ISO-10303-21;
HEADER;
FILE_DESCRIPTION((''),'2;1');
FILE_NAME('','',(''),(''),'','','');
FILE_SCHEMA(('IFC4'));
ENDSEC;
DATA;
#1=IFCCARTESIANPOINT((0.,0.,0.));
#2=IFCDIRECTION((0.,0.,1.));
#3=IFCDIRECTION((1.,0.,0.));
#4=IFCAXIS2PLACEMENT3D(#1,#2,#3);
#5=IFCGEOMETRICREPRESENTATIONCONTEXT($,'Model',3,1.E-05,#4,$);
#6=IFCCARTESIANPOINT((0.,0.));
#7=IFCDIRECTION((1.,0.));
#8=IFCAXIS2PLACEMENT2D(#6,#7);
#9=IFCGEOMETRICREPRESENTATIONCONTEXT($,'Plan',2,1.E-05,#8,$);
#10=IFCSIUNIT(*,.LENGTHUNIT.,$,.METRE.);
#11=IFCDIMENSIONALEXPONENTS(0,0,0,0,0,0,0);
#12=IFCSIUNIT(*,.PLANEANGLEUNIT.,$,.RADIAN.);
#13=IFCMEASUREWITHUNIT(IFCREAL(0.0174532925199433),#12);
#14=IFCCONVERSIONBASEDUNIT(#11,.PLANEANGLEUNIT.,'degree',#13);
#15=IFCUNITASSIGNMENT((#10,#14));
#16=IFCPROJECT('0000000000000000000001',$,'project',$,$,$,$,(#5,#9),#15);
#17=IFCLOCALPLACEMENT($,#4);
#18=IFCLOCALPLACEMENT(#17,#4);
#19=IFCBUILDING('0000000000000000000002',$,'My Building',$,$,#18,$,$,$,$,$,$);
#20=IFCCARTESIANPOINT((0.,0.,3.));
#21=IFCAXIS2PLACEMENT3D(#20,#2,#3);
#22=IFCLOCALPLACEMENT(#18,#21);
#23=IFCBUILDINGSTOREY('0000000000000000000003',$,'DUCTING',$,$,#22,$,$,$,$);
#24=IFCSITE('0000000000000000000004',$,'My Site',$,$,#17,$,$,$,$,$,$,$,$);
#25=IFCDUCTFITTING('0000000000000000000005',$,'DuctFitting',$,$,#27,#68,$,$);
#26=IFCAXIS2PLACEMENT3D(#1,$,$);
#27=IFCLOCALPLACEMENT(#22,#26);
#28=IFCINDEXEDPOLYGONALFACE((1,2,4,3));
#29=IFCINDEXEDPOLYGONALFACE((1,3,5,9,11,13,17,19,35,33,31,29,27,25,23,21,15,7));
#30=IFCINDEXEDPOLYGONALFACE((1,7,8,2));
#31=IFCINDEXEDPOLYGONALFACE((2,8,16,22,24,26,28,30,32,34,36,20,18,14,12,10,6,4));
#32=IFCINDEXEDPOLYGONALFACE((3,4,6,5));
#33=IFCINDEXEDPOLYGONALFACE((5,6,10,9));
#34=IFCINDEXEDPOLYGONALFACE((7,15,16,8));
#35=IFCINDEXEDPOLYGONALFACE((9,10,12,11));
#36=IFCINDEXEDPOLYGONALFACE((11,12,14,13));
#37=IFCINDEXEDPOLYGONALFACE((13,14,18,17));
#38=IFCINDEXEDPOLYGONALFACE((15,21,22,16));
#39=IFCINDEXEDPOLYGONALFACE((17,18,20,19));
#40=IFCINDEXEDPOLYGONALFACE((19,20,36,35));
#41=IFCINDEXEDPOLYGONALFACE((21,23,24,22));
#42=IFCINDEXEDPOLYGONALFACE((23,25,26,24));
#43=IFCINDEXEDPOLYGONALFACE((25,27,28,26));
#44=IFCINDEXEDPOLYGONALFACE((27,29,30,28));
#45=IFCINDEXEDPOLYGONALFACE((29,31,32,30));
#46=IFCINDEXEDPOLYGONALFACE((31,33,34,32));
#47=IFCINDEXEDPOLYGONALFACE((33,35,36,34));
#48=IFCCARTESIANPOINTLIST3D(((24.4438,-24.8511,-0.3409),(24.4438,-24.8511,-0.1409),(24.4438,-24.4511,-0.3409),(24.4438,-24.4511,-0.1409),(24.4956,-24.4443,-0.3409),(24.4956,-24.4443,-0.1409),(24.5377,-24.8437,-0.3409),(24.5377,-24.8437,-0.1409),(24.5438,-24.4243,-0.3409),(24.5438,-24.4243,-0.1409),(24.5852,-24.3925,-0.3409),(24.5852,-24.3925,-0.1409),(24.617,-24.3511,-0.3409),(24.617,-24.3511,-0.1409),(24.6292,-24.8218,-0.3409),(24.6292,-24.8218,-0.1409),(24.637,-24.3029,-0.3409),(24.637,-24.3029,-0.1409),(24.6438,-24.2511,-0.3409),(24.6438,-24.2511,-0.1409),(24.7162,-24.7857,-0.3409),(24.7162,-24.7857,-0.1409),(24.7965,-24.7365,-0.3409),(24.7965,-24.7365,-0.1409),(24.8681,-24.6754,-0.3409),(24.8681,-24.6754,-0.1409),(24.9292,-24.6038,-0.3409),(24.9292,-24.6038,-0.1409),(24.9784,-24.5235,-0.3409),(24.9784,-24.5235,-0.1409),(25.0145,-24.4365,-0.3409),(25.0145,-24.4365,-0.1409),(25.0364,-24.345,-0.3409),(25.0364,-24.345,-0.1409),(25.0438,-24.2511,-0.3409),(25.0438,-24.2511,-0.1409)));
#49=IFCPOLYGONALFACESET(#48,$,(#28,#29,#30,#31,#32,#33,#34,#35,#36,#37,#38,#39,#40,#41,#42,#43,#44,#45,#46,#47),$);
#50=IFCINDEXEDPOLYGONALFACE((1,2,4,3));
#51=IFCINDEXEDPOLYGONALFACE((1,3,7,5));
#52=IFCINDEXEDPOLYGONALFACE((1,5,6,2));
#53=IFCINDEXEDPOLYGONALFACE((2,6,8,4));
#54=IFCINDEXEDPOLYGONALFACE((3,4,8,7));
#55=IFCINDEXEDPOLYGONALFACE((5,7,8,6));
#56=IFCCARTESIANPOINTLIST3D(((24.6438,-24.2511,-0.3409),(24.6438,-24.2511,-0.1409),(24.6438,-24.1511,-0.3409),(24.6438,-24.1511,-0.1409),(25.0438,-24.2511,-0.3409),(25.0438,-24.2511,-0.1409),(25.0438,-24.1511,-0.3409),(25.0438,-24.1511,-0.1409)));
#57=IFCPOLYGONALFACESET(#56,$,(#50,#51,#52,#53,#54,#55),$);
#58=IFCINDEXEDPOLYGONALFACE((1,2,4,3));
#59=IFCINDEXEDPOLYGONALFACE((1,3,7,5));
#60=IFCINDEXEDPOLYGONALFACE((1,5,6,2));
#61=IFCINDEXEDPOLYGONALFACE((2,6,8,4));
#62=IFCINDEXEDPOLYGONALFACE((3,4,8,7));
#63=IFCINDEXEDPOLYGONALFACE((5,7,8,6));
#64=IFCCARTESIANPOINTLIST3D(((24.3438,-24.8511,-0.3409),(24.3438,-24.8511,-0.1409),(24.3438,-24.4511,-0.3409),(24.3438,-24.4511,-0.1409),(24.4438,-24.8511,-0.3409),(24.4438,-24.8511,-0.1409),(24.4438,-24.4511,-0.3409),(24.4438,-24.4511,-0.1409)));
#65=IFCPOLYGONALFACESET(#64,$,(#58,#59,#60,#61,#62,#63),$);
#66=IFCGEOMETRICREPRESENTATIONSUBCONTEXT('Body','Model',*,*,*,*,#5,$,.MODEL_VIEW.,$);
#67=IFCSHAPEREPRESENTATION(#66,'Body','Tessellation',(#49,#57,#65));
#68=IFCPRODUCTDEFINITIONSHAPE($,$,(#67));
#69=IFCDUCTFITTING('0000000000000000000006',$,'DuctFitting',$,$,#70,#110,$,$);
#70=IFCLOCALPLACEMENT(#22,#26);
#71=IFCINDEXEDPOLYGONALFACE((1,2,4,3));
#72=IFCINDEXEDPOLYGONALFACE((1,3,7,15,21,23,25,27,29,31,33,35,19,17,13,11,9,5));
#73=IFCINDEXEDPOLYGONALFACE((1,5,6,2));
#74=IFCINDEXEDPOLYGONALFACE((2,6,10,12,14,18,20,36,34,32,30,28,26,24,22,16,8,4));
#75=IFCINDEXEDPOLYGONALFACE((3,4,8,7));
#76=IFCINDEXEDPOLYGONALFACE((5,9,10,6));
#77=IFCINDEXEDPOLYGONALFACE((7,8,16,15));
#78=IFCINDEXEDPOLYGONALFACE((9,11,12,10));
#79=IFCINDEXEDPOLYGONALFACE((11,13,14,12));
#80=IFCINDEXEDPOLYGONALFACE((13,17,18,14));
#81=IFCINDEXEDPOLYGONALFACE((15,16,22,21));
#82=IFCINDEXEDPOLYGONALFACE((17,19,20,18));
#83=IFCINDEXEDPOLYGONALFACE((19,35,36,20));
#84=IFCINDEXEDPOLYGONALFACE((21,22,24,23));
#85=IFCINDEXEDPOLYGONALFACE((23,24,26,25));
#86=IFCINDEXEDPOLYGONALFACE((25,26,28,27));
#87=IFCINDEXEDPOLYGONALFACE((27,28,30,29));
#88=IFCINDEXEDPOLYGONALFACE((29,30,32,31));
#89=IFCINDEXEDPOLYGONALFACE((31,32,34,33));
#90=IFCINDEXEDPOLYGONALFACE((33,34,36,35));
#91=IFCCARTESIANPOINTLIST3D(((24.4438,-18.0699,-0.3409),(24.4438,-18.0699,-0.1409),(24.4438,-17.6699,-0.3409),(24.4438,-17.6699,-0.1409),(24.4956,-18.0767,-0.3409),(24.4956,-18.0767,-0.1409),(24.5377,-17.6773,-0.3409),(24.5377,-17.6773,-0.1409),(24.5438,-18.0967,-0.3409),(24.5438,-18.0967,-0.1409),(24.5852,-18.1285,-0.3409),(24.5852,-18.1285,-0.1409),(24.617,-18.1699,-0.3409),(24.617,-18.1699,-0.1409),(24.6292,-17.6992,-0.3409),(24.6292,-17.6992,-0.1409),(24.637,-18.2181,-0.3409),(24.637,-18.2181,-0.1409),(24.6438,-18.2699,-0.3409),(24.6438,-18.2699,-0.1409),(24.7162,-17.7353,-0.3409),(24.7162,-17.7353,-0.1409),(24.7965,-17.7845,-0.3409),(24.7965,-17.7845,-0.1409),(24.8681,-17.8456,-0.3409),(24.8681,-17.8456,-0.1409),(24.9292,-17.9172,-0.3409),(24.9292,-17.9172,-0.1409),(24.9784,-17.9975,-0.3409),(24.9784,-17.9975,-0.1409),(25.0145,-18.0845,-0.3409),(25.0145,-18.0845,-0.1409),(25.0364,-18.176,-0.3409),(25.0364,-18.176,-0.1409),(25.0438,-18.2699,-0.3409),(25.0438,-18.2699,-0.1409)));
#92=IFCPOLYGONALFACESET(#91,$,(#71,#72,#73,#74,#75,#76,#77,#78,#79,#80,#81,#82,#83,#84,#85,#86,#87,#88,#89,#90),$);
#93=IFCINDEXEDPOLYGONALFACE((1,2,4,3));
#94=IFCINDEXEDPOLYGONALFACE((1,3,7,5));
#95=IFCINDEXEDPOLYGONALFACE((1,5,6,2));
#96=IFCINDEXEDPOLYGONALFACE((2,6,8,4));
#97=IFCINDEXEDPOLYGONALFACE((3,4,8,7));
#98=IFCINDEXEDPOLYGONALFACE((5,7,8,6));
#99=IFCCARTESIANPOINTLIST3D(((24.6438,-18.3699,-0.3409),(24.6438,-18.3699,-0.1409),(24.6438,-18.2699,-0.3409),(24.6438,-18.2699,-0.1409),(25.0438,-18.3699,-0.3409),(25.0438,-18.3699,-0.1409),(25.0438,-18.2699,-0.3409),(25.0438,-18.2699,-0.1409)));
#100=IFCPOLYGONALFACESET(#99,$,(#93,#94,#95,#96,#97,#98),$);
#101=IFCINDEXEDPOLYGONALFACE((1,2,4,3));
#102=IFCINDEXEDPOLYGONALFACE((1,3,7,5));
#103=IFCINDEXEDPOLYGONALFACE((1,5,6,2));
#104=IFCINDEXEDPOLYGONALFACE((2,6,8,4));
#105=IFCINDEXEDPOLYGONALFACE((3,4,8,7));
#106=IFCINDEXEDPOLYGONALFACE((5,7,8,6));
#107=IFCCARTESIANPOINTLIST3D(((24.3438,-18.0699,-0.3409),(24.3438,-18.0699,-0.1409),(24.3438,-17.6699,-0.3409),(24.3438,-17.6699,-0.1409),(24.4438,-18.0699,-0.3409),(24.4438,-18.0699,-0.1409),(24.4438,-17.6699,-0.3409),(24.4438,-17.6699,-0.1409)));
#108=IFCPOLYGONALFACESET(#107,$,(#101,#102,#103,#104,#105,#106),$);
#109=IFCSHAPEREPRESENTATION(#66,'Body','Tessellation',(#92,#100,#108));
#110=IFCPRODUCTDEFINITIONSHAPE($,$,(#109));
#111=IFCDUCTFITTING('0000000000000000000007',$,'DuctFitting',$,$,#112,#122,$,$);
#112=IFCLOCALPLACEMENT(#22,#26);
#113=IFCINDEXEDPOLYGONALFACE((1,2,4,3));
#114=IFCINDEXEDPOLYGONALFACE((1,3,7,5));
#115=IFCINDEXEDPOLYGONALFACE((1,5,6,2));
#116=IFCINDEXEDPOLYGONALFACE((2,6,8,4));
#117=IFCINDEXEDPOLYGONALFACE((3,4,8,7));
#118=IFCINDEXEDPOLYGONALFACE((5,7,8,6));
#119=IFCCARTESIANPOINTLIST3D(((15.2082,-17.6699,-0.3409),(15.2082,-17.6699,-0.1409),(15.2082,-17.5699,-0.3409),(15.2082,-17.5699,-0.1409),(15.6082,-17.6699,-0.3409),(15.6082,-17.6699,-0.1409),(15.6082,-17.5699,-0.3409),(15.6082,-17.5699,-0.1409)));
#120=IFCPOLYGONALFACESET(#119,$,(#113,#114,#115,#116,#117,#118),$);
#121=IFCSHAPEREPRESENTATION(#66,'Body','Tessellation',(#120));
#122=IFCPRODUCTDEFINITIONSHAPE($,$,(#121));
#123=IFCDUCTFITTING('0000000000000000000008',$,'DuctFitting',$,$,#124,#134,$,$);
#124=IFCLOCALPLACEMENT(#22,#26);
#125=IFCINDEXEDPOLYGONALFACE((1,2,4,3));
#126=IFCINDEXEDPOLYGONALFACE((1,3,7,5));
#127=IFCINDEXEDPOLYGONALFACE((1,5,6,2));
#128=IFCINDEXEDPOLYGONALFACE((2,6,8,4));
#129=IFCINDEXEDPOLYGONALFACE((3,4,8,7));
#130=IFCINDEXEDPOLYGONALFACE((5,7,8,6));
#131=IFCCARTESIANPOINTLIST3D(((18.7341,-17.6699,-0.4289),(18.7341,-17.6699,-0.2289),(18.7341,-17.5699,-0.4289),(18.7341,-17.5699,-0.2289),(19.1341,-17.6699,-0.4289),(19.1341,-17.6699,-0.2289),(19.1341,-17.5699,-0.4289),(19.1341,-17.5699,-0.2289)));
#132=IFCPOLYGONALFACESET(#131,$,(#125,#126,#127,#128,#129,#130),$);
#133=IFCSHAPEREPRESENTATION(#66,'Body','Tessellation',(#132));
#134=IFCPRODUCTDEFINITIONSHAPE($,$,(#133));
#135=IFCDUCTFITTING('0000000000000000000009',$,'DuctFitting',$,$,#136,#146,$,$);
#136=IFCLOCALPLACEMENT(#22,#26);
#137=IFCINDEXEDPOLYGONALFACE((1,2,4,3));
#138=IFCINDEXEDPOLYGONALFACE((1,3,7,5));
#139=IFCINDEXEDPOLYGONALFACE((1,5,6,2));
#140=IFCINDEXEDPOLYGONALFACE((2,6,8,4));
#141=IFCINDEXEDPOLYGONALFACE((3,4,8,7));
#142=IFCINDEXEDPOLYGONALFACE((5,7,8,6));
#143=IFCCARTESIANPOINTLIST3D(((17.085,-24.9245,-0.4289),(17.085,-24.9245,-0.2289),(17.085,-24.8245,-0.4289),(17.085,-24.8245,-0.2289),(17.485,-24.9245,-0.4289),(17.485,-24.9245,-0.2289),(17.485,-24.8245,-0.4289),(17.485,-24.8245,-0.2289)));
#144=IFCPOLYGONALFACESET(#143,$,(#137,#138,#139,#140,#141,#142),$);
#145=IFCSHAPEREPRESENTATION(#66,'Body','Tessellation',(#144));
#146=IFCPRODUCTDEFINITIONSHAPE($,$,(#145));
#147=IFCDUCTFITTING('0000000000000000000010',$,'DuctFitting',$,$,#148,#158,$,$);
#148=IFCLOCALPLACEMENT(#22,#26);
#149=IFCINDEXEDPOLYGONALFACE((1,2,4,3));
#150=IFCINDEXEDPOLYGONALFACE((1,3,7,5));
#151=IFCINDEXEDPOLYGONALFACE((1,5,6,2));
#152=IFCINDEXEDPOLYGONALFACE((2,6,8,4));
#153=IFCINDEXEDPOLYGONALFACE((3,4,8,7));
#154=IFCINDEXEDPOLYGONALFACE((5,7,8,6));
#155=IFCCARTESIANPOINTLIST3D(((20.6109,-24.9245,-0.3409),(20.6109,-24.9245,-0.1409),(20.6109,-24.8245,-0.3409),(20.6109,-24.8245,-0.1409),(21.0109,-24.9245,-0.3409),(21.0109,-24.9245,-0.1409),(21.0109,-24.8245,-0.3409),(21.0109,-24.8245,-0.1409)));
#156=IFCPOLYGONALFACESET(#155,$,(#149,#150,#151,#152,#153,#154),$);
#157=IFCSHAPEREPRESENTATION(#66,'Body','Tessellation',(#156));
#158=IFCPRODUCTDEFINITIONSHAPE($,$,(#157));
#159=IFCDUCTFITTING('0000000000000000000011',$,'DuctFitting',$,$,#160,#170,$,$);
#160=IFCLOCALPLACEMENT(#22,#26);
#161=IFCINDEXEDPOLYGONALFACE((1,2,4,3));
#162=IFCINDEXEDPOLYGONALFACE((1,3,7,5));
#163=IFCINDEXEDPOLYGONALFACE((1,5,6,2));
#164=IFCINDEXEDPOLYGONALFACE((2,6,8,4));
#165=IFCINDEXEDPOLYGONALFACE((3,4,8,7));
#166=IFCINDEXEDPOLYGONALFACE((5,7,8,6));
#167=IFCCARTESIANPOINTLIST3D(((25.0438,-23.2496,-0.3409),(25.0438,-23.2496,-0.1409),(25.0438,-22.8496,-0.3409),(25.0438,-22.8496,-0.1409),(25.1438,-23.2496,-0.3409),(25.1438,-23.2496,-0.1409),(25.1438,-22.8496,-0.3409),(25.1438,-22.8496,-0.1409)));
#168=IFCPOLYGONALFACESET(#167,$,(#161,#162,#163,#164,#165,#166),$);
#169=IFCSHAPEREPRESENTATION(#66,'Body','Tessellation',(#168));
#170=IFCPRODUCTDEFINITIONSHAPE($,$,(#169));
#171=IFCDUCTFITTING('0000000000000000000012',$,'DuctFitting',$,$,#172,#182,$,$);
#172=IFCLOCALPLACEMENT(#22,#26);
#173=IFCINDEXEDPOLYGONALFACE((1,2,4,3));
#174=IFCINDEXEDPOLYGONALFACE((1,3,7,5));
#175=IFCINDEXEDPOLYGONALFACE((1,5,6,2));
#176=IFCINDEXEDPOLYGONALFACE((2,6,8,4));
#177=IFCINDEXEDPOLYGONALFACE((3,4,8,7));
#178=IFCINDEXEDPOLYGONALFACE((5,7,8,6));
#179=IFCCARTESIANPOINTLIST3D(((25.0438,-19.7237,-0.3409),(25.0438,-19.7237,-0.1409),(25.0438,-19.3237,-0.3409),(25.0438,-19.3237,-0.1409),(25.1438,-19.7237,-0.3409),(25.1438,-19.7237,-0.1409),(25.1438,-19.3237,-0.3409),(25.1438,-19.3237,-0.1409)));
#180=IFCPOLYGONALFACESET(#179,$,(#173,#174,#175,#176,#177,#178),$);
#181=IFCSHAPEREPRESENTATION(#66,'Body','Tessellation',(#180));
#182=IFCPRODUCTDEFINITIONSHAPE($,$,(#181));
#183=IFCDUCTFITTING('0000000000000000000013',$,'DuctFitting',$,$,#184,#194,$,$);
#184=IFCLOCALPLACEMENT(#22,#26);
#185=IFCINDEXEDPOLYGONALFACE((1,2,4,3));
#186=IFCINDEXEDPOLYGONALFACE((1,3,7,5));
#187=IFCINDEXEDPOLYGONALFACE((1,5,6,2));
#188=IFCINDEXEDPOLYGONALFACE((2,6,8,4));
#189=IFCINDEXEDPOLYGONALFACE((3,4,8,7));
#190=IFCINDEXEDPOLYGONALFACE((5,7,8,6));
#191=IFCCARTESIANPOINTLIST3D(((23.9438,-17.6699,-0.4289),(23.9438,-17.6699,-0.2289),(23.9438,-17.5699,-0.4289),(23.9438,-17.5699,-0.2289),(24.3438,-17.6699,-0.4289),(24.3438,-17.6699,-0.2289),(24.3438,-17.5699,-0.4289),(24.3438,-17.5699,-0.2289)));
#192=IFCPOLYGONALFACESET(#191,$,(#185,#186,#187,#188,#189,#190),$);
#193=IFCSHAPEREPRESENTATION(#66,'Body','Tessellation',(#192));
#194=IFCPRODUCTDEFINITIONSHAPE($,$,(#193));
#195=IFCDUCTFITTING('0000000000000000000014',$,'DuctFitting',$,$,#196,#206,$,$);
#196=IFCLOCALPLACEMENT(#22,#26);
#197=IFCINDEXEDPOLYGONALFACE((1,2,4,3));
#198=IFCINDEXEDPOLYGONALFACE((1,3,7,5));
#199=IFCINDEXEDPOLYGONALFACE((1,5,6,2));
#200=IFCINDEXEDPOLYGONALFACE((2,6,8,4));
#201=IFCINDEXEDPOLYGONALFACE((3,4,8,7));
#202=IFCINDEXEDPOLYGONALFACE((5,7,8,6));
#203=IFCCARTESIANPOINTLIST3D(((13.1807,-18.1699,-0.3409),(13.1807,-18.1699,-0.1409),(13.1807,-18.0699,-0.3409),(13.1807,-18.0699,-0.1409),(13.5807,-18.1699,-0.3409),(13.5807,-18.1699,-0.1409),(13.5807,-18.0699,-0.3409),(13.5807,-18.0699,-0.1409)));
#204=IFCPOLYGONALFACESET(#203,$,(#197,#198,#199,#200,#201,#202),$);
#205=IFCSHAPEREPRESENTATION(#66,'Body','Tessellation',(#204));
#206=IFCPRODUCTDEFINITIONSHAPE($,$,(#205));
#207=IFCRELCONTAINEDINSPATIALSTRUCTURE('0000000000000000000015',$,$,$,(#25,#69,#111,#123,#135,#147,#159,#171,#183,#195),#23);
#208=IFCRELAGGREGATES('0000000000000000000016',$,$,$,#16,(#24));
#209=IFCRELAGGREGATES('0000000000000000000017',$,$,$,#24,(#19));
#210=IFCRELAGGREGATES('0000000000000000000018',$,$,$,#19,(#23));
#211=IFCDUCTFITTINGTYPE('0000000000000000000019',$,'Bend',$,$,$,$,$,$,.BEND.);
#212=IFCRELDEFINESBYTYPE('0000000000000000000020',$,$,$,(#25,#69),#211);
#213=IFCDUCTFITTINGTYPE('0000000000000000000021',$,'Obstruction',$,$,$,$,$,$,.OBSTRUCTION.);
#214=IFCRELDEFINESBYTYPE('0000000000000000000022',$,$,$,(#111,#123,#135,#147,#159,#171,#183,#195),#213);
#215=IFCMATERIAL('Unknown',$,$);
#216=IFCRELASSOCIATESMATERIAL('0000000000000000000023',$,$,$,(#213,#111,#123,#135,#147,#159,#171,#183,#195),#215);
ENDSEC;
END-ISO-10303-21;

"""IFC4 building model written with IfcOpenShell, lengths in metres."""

from ifc_helpers import new_model, entity, si_unit, converted_unit, frame, origin_with_axes, origin_2d_with_axis, place, context, subcontext, project, spatial, line, arc, indexed_curve, rectangle, outline, extrude, source, transform, mapped, material, material_profile, profile_set, profile_usage, type_object, type_shapes, element, save


model = new_model("IFC4")

# Units and contexts
model_context = context("Model", 3, precision=1e-05, world=origin_with_axes())
plan_context = context("Plan", 2, precision=1e-05, world=origin_2d_with_axis())
body_context = subcontext(model_context, "Body", "Model", "MODEL_VIEW")
ifc_project = project(units=[si_unit("LENGTHUNIT", "METRE"), converted_unit("PLANEANGLEUNIT", "degree", entity("IfcReal", 0.0174532925199433), si_unit("PLANEANGLEUNIT", "RADIAN"), dimensions=[0, 0, 0, 0, 0, 0, 0])], contexts=[model_context, plan_context])

# Site, building, storey
site_placement = place(None, origin_with_axes())
site = spatial("IfcSite", under=ifc_project, at=site_placement, Name="My Site")
building_placement = place(site_placement, origin_with_axes())
building = spatial("IfcBuilding", under=site, at=building_placement, Name="My Building")
storey_placement = place(building_placement, frame((0.0, 0.0, 3.0), z_axis=(0.0, 0.0, 1.0), x_axis=(1.0, 0.0, 0.0)))
storey = spatial("IfcBuildingStorey", under=building, at=storey_placement, Name="DUCTING")

# Shared definitions
ifc_material = material(Name="Unknown")

# Duct fittings
duct_fitting_type_1 = type_object("IfcDuctFittingType", Name="Bend", PredefinedType="BEND")
shared_shape = source(origin_with_axes(), body_context, "Body", "SweptSolid", [
    extrude(outline(indexed_curve([(-0.2, 0.0), (-0.2586, -0.1414), (-0.4, -0.2), (-0.4, -0.6), (0.0243, -0.4243), (0.2, 0.0)], segments=[arc(1, 2, 3), line(3, 4), arc(4, 5, 6), line(6, 1)])), frame((0.0, -0.1, -0.1), z_axis=(0.0, -1.0, 0.0), x_axis=(1.0, 0.0, 0.0)), (0.0, 0.0, -1.0), 0.2),
    extrude(rectangle(XDim=0.4, YDim=0.2), origin_with_axes(), (0.0, 0.0, -1.0), 0.1),
    extrude(rectangle(XDim=0.4, YDim=0.2), frame((-0.4, 0.0, -0.5), z_axis=(-1.0, 0.0, 0.0), x_axis=(0.0, 0.0, -1.0)), (0.0, 0.0, 1.0), 0.1),
])
type_shapes(duct_fitting_type_1, [shared_shape])
for number, where, z_axis, x_axis, name in (
    (1, (24.8438, -24.1511, -0.2409), (0.0, 1.0, 0.0), (1.0, 0.0, 0.0), "DuctFitting"),
    (2, (24.8438, -18.3699, -0.2409), (0.0, -1.0, 0.0), (1.0, 0.0, 0.0), "DuctFitting"),
):
    element("IfcDuctFitting", number, at=place(storey_placement, frame(where, z_axis=z_axis, x_axis=x_axis)), inside=storey, type_object=duct_fitting_type_1, Name=name, context=body_context, shape_type="MappedRepresentation", body=[
        mapped(shared_shape, transform((0.0, 0.0, 0.0), x_axis=(1.0, 0.0, 0.0), y_axis=(0.0, 1.0, 0.0), z_axis=(0.0, 0.0, 1.0), scale=1.0)),
    ])
ifc_material_profile_1 = material_profile(ifc_material, rectangle(XDim=0.4, YDim=0.2))
ifc_profile_set_1 = profile_set([ifc_material_profile_1])
ifc_profile_usage_1 = profile_usage(ifc_profile_set_1, cardinal=5)
duct_fitting_type_2 = type_object("IfcDuctFittingType", Name="Obstruction", PredefinedType="OBSTRUCTION", material=ifc_profile_set_1)
duct_fitting_1_placement = place(storey_placement, frame((15.4082, -17.6699, -0.2409), z_axis=(0.0, 1.0, 0.0), x_axis=(-1.0, 0.0, 0.0)))
element("IfcDuctFitting", 3, at=duct_fitting_1_placement, inside=storey, type_object=duct_fitting_type_2, material=ifc_profile_usage_1, Name="DuctFitting", context=body_context, shape_type="SweptSolid", body=[
    extrude(rectangle(XDim=0.4, YDim=0.2), origin_with_axes(), (0.0, 0.0, 1.0), 0.1),
])
ifc_profile_usage_2 = profile_usage(ifc_profile_set_1, cardinal=5)
duct_fitting_2_placement = place(storey_placement, frame((18.9341, -17.6699, -0.3289), z_axis=(0.0, 1.0, 0.0), x_axis=(-1.0, 0.0, 0.0)))
element("IfcDuctFitting", 4, at=duct_fitting_2_placement, inside=storey, type_object=duct_fitting_type_2, material=ifc_profile_usage_2, Name="DuctFitting", context=body_context, shape_type="SweptSolid", body=[
    extrude(rectangle(XDim=0.4, YDim=0.2), origin_with_axes(), (0.0, 0.0, 1.0), 0.1),
])
ifc_profile_usage_3 = profile_usage(ifc_profile_set_1, cardinal=5)
duct_fitting_3_placement = place(storey_placement, frame((17.285, -24.8245, -0.3289), z_axis=(0.0, -1.0, 0.0), x_axis=(1.0, 0.0, 0.0)))
element("IfcDuctFitting", 5, at=duct_fitting_3_placement, inside=storey, type_object=duct_fitting_type_2, material=ifc_profile_usage_3, Name="DuctFitting", context=body_context, shape_type="SweptSolid", body=[
    extrude(rectangle(XDim=0.4, YDim=0.2), origin_with_axes(), (0.0, 0.0, 1.0), 0.1),
])
ifc_profile_usage_4 = profile_usage(ifc_profile_set_1, cardinal=5)
duct_fitting_4_placement = place(storey_placement, frame((20.8109, -24.8245, -0.2409), z_axis=(0.0, -1.0, 0.0), x_axis=(1.0, 0.0, 0.0)))
element("IfcDuctFitting", 6, at=duct_fitting_4_placement, inside=storey, type_object=duct_fitting_type_2, material=ifc_profile_usage_4, Name="DuctFitting", context=body_context, shape_type="SweptSolid", body=[
    extrude(rectangle(XDim=0.4, YDim=0.2), origin_with_axes(), (0.0, 0.0, 1.0), 0.1),
])
ifc_profile_usage_5 = profile_usage(ifc_profile_set_1, cardinal=5)
duct_fitting_5_placement = place(storey_placement, frame((25.0438, -23.0496, -0.2409), z_axis=(1.0, 0.0, 0.0), x_axis=(0.0, 1.0, 0.0)))
element("IfcDuctFitting", 7, at=duct_fitting_5_placement, inside=storey, type_object=duct_fitting_type_2, material=ifc_profile_usage_5, Name="DuctFitting", context=body_context, shape_type="SweptSolid", body=[
    extrude(rectangle(XDim=0.4, YDim=0.2), origin_with_axes(), (0.0, 0.0, 1.0), 0.1),
])
ifc_profile_usage_6 = profile_usage(ifc_profile_set_1, cardinal=5)
duct_fitting_6_placement = place(storey_placement, frame((25.0438, -19.5237, -0.2409), z_axis=(1.0, 0.0, 0.0), x_axis=(0.0, 1.0, 0.0)))
element("IfcDuctFitting", 8, at=duct_fitting_6_placement, inside=storey, type_object=duct_fitting_type_2, material=ifc_profile_usage_6, Name="DuctFitting", context=body_context, shape_type="SweptSolid", body=[
    extrude(rectangle(XDim=0.4, YDim=0.2), origin_with_axes(), (0.0, 0.0, 1.0), 0.1),
])
ifc_profile_usage_7 = profile_usage(ifc_profile_set_1, cardinal=5)
duct_fitting_7_placement = place(storey_placement, frame((24.1438, -17.6699, -0.3289), z_axis=(0.0, 1.0, 0.0), x_axis=(-1.0, 0.0, 0.0)))
element("IfcDuctFitting", 9, at=duct_fitting_7_placement, inside=storey, type_object=duct_fitting_type_2, material=ifc_profile_usage_7, Name="DuctFitting", context=body_context, shape_type="SweptSolid", body=[
    extrude(rectangle(XDim=0.4, YDim=0.2), origin_with_axes(), (0.0, 0.0, 1.0), 0.1),
])
ifc_profile_usage_8 = profile_usage(ifc_profile_set_1, cardinal=5)
duct_fitting_8_placement = place(storey_placement, frame((13.3807, -18.0699, -0.2409), z_axis=(0.0, -1.0, 0.0), x_axis=(1.0, 0.0, 0.0)))
element("IfcDuctFitting", 10, at=duct_fitting_8_placement, inside=storey, type_object=duct_fitting_type_2, material=ifc_profile_usage_8, Name="DuctFitting", context=body_context, shape_type="SweptSolid", body=[
    extrude(rectangle(XDim=0.4, YDim=0.2), origin_with_axes(), (0.0, 0.0, 1.0), 0.1),
])

save(model, "model.ifc")
